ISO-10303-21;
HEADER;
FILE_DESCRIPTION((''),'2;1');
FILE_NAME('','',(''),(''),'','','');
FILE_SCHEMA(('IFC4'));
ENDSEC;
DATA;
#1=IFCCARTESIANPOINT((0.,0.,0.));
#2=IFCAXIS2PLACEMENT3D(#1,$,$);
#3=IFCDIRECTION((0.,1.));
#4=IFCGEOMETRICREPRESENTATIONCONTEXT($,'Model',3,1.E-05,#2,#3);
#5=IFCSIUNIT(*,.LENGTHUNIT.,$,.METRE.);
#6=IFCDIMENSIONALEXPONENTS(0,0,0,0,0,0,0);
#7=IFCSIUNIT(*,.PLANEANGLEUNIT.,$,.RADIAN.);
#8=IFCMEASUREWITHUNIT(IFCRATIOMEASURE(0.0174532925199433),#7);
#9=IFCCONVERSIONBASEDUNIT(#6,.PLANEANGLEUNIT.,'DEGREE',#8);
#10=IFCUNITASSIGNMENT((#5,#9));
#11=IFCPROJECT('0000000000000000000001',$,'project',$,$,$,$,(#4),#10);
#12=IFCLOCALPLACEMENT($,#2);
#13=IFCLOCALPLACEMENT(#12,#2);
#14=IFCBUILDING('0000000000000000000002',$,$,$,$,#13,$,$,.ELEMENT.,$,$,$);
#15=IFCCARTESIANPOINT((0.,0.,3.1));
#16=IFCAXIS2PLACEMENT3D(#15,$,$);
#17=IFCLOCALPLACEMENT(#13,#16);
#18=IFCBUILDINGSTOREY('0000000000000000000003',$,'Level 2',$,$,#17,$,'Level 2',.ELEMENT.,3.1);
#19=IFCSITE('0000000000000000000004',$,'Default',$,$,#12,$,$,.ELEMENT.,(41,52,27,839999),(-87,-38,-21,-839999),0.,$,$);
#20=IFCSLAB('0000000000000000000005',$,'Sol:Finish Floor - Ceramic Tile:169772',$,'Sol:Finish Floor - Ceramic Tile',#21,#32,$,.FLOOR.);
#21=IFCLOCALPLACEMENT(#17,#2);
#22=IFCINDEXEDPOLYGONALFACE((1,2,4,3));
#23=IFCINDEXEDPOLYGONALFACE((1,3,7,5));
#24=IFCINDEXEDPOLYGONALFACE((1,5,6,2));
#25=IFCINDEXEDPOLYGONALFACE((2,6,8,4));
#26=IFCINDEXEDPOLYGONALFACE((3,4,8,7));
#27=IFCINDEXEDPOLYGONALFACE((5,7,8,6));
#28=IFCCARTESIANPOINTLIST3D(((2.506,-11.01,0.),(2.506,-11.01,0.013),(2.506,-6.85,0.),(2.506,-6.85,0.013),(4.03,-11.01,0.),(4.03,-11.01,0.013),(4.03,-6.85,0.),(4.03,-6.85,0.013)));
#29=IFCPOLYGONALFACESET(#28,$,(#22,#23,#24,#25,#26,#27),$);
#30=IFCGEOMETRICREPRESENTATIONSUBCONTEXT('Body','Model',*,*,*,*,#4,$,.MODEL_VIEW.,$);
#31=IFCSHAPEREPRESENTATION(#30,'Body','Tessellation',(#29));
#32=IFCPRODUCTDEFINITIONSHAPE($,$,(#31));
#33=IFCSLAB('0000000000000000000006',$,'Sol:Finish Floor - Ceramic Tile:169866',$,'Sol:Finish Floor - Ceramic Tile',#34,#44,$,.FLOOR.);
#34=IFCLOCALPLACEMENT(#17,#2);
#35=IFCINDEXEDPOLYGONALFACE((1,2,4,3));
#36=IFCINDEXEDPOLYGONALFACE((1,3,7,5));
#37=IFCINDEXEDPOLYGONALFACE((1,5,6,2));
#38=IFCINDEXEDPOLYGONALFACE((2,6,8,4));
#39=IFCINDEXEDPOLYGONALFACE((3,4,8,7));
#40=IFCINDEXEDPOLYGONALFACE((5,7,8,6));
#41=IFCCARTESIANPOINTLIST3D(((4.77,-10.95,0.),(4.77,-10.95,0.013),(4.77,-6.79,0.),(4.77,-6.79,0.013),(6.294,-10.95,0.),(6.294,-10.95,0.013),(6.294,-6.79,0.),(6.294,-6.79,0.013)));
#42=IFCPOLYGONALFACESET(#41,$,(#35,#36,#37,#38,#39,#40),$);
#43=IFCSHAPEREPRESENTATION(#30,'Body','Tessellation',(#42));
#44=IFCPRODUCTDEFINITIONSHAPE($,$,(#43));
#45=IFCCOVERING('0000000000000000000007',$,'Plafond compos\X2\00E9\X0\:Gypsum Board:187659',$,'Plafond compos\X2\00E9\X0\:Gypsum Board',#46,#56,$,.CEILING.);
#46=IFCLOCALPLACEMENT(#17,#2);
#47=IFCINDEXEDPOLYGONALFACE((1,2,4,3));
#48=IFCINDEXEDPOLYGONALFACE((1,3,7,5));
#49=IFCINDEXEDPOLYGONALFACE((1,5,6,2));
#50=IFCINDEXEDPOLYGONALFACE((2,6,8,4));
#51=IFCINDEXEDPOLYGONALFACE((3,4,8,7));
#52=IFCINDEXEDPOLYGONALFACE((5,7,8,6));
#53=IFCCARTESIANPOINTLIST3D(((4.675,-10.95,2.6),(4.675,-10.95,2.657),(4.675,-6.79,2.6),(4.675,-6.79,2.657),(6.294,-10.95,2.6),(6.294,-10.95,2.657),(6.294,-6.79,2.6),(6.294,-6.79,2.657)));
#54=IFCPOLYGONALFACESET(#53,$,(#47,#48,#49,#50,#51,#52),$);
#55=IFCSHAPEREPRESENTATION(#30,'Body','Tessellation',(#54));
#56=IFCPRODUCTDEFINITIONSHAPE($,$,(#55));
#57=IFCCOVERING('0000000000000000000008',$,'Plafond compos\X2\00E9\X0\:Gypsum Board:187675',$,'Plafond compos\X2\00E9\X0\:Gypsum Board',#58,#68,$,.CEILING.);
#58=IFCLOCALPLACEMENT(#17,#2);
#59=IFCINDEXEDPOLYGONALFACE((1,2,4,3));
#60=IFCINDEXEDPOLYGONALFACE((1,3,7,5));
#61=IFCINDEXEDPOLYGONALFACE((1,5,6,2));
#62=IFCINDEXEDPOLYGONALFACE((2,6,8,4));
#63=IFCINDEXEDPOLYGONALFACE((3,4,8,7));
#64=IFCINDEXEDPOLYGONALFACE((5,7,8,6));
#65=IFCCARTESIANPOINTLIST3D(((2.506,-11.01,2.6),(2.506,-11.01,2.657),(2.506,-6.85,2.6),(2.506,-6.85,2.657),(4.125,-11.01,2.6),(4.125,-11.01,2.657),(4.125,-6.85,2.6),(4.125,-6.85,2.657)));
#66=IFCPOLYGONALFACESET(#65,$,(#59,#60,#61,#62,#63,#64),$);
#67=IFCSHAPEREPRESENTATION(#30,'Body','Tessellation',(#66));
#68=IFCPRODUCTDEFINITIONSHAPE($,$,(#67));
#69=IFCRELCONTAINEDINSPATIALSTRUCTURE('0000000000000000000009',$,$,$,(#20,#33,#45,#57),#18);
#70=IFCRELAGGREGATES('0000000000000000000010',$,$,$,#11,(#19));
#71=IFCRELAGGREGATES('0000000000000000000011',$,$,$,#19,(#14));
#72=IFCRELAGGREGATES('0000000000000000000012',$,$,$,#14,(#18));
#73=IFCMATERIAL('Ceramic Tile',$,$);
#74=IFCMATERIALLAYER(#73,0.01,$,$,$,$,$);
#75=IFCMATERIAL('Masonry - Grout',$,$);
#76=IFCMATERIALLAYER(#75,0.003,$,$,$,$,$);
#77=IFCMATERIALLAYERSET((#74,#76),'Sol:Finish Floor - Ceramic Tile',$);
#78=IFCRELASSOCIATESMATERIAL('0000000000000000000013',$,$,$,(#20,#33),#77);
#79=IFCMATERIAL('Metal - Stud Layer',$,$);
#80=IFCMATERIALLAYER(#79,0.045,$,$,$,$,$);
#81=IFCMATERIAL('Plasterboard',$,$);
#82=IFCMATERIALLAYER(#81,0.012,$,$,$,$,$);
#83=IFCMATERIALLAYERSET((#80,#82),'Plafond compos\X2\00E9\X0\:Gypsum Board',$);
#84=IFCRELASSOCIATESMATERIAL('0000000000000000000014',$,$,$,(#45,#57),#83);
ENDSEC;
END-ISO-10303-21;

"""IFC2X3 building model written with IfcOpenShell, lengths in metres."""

from ifc_helpers import new_model, entity, si_unit, converted_unit, direction, frame, frame_2d, origin, place, context, subcontext, project, spatial, rectangle, extrude, material, layer, layer_set, layer_usage, element, save


model = new_model("IFC2X3")

# Units and contexts
model_context = context("Model", 3, precision=1e-05, world=origin(), true_north=direction((0.0, 1.0)))
body_context = subcontext(model_context, "Body", "Model", "MODEL_VIEW")
ifc_project = project(units=[si_unit("LENGTHUNIT", "METRE"), converted_unit("PLANEANGLEUNIT", "DEGREE", entity("IfcRatioMeasure", 0.0174532925199433), si_unit("PLANEANGLEUNIT", "RADIAN"), dimensions=[0, 0, 0, 0, 0, 0, 0])], contexts=[model_context])

# Site, building, storey
site_placement = place(None, origin())
site = spatial("IfcSite", under=ifc_project, at=site_placement, Name="Default", CompositionType="ELEMENT", RefLatitude=(41, 52, 27, 839999), RefLongitude=(-87, -38, -21, -839999), RefElevation=0.0)
building_placement = place(site_placement, origin())
building = spatial("IfcBuilding", under=site, at=building_placement, CompositionType="ELEMENT")
storey_placement = place(building_placement, frame((0.0, 0.0, 3.1)))
storey = spatial("IfcBuildingStorey", under=building, at=storey_placement, Name="Level 2", LongName="Level 2", CompositionType="ELEMENT", Elevation=3.1)

# Slabs
ifc_material_1 = material(Name="Ceramic Tile")
ifc_layer_1 = layer(ifc_material_1, 0.01)
ifc_material_2 = material(Name="Masonry - Grout")
ifc_layer_2 = layer(ifc_material_2, 0.003)
ifc_layer_set_1 = layer_set([ifc_layer_1, ifc_layer_2], Name="Sol:Finish Floor - Ceramic Tile")
ifc_layer_usage_1 = layer_usage(ifc_layer_set_1, "AXIS3", "POSITIVE", 0.0)
slab_1_placement = place(storey_placement, origin())
element("IfcSlab", 1, at=slab_1_placement, inside=storey, material=ifc_layer_usage_1, Name="Sol:Finish Floor - Ceramic Tile:169772", ObjectType="Sol:Finish Floor - Ceramic Tile", PredefinedType="FLOOR", context=body_context, shape_type="SweptSolid", body=[
    extrude(rectangle(XDim=4.16, YDim=1.524, at=frame_2d((0.0, 0.0), x_axis=(1.0, 0.0))), frame((3.268, -8.93, 0.013), z_axis=(0.0, 0.0, -1.0), x_axis=(0.0, 1.0, 0.0)), (0.0, 0.0, 1.0), 0.013),
])
ifc_layer_usage_2 = layer_usage(ifc_layer_set_1, "AXIS3", "POSITIVE", 0.0)
slab_2_placement = place(storey_placement, origin())
element("IfcSlab", 2, at=slab_2_placement, inside=storey, material=ifc_layer_usage_2, Name="Sol:Finish Floor - Ceramic Tile:169866", ObjectType="Sol:Finish Floor - Ceramic Tile", PredefinedType="FLOOR", context=body_context, shape_type="SweptSolid", body=[
    extrude(rectangle(XDim=4.16, YDim=1.524, at=frame_2d((0.0, 0.0), x_axis=(1.0, 0.0))), frame((5.532, -8.87, 0.013), z_axis=(0.0, 0.0, -1.0), x_axis=(0.0, 1.0, 0.0)), (0.0, 0.0, 1.0), 0.013),
])

# Shared definitions
ifc_material_3 = material(Name="Metal - Stud Layer")
ifc_material_4 = material(Name="Plasterboard")

# Shared definitions
ifc_layer_3 = layer(ifc_material_3, 0.045)
ifc_layer_4 = layer(ifc_material_4, 0.012)
ifc_layer_set_2 = layer_set([ifc_layer_3, ifc_layer_4], Name="Plafond composé:Gypsum Board")

# Coverings
ifc_layer_usage_3 = layer_usage(ifc_layer_set_2, "AXIS3", "NEGATIVE", 0.0)
covering_1_placement = place(storey_placement, origin())
element("IfcCovering", 3, at=covering_1_placement, inside=storey, material=ifc_layer_usage_3, Name="Plafond composé:Gypsum Board:187659", ObjectType="Plafond composé:Gypsum Board", PredefinedType="CEILING", context=body_context, shape_type="SweptSolid", body=[
    extrude(rectangle(XDim=1.619, YDim=4.16, at=frame_2d((0.0, 0.0), x_axis=(1.0, 0.0))), frame((5.4845, -8.87, 2.6)), (0.0, 0.0, 1.0), 0.057),
])
ifc_layer_usage_4 = layer_usage(ifc_layer_set_2, "AXIS3", "NEGATIVE", 0.0)
covering_2_placement = place(storey_placement, origin())
element("IfcCovering", 4, at=covering_2_placement, inside=storey, material=ifc_layer_usage_4, Name="Plafond composé:Gypsum Board:187675", ObjectType="Plafond composé:Gypsum Board", PredefinedType="CEILING", context=body_context, shape_type="SweptSolid", body=[
    extrude(rectangle(XDim=1.619, YDim=4.16, at=frame_2d((0.0, 0.0), x_axis=(1.0, 0.0))), frame((3.3155, -8.93, 2.6), z_axis=(0.0, 0.0, 1.0), x_axis=(-1.0, 0.0, 0.0)), (0.0, 0.0, 1.0), 0.057),
])

save(model, "model.ifc")
